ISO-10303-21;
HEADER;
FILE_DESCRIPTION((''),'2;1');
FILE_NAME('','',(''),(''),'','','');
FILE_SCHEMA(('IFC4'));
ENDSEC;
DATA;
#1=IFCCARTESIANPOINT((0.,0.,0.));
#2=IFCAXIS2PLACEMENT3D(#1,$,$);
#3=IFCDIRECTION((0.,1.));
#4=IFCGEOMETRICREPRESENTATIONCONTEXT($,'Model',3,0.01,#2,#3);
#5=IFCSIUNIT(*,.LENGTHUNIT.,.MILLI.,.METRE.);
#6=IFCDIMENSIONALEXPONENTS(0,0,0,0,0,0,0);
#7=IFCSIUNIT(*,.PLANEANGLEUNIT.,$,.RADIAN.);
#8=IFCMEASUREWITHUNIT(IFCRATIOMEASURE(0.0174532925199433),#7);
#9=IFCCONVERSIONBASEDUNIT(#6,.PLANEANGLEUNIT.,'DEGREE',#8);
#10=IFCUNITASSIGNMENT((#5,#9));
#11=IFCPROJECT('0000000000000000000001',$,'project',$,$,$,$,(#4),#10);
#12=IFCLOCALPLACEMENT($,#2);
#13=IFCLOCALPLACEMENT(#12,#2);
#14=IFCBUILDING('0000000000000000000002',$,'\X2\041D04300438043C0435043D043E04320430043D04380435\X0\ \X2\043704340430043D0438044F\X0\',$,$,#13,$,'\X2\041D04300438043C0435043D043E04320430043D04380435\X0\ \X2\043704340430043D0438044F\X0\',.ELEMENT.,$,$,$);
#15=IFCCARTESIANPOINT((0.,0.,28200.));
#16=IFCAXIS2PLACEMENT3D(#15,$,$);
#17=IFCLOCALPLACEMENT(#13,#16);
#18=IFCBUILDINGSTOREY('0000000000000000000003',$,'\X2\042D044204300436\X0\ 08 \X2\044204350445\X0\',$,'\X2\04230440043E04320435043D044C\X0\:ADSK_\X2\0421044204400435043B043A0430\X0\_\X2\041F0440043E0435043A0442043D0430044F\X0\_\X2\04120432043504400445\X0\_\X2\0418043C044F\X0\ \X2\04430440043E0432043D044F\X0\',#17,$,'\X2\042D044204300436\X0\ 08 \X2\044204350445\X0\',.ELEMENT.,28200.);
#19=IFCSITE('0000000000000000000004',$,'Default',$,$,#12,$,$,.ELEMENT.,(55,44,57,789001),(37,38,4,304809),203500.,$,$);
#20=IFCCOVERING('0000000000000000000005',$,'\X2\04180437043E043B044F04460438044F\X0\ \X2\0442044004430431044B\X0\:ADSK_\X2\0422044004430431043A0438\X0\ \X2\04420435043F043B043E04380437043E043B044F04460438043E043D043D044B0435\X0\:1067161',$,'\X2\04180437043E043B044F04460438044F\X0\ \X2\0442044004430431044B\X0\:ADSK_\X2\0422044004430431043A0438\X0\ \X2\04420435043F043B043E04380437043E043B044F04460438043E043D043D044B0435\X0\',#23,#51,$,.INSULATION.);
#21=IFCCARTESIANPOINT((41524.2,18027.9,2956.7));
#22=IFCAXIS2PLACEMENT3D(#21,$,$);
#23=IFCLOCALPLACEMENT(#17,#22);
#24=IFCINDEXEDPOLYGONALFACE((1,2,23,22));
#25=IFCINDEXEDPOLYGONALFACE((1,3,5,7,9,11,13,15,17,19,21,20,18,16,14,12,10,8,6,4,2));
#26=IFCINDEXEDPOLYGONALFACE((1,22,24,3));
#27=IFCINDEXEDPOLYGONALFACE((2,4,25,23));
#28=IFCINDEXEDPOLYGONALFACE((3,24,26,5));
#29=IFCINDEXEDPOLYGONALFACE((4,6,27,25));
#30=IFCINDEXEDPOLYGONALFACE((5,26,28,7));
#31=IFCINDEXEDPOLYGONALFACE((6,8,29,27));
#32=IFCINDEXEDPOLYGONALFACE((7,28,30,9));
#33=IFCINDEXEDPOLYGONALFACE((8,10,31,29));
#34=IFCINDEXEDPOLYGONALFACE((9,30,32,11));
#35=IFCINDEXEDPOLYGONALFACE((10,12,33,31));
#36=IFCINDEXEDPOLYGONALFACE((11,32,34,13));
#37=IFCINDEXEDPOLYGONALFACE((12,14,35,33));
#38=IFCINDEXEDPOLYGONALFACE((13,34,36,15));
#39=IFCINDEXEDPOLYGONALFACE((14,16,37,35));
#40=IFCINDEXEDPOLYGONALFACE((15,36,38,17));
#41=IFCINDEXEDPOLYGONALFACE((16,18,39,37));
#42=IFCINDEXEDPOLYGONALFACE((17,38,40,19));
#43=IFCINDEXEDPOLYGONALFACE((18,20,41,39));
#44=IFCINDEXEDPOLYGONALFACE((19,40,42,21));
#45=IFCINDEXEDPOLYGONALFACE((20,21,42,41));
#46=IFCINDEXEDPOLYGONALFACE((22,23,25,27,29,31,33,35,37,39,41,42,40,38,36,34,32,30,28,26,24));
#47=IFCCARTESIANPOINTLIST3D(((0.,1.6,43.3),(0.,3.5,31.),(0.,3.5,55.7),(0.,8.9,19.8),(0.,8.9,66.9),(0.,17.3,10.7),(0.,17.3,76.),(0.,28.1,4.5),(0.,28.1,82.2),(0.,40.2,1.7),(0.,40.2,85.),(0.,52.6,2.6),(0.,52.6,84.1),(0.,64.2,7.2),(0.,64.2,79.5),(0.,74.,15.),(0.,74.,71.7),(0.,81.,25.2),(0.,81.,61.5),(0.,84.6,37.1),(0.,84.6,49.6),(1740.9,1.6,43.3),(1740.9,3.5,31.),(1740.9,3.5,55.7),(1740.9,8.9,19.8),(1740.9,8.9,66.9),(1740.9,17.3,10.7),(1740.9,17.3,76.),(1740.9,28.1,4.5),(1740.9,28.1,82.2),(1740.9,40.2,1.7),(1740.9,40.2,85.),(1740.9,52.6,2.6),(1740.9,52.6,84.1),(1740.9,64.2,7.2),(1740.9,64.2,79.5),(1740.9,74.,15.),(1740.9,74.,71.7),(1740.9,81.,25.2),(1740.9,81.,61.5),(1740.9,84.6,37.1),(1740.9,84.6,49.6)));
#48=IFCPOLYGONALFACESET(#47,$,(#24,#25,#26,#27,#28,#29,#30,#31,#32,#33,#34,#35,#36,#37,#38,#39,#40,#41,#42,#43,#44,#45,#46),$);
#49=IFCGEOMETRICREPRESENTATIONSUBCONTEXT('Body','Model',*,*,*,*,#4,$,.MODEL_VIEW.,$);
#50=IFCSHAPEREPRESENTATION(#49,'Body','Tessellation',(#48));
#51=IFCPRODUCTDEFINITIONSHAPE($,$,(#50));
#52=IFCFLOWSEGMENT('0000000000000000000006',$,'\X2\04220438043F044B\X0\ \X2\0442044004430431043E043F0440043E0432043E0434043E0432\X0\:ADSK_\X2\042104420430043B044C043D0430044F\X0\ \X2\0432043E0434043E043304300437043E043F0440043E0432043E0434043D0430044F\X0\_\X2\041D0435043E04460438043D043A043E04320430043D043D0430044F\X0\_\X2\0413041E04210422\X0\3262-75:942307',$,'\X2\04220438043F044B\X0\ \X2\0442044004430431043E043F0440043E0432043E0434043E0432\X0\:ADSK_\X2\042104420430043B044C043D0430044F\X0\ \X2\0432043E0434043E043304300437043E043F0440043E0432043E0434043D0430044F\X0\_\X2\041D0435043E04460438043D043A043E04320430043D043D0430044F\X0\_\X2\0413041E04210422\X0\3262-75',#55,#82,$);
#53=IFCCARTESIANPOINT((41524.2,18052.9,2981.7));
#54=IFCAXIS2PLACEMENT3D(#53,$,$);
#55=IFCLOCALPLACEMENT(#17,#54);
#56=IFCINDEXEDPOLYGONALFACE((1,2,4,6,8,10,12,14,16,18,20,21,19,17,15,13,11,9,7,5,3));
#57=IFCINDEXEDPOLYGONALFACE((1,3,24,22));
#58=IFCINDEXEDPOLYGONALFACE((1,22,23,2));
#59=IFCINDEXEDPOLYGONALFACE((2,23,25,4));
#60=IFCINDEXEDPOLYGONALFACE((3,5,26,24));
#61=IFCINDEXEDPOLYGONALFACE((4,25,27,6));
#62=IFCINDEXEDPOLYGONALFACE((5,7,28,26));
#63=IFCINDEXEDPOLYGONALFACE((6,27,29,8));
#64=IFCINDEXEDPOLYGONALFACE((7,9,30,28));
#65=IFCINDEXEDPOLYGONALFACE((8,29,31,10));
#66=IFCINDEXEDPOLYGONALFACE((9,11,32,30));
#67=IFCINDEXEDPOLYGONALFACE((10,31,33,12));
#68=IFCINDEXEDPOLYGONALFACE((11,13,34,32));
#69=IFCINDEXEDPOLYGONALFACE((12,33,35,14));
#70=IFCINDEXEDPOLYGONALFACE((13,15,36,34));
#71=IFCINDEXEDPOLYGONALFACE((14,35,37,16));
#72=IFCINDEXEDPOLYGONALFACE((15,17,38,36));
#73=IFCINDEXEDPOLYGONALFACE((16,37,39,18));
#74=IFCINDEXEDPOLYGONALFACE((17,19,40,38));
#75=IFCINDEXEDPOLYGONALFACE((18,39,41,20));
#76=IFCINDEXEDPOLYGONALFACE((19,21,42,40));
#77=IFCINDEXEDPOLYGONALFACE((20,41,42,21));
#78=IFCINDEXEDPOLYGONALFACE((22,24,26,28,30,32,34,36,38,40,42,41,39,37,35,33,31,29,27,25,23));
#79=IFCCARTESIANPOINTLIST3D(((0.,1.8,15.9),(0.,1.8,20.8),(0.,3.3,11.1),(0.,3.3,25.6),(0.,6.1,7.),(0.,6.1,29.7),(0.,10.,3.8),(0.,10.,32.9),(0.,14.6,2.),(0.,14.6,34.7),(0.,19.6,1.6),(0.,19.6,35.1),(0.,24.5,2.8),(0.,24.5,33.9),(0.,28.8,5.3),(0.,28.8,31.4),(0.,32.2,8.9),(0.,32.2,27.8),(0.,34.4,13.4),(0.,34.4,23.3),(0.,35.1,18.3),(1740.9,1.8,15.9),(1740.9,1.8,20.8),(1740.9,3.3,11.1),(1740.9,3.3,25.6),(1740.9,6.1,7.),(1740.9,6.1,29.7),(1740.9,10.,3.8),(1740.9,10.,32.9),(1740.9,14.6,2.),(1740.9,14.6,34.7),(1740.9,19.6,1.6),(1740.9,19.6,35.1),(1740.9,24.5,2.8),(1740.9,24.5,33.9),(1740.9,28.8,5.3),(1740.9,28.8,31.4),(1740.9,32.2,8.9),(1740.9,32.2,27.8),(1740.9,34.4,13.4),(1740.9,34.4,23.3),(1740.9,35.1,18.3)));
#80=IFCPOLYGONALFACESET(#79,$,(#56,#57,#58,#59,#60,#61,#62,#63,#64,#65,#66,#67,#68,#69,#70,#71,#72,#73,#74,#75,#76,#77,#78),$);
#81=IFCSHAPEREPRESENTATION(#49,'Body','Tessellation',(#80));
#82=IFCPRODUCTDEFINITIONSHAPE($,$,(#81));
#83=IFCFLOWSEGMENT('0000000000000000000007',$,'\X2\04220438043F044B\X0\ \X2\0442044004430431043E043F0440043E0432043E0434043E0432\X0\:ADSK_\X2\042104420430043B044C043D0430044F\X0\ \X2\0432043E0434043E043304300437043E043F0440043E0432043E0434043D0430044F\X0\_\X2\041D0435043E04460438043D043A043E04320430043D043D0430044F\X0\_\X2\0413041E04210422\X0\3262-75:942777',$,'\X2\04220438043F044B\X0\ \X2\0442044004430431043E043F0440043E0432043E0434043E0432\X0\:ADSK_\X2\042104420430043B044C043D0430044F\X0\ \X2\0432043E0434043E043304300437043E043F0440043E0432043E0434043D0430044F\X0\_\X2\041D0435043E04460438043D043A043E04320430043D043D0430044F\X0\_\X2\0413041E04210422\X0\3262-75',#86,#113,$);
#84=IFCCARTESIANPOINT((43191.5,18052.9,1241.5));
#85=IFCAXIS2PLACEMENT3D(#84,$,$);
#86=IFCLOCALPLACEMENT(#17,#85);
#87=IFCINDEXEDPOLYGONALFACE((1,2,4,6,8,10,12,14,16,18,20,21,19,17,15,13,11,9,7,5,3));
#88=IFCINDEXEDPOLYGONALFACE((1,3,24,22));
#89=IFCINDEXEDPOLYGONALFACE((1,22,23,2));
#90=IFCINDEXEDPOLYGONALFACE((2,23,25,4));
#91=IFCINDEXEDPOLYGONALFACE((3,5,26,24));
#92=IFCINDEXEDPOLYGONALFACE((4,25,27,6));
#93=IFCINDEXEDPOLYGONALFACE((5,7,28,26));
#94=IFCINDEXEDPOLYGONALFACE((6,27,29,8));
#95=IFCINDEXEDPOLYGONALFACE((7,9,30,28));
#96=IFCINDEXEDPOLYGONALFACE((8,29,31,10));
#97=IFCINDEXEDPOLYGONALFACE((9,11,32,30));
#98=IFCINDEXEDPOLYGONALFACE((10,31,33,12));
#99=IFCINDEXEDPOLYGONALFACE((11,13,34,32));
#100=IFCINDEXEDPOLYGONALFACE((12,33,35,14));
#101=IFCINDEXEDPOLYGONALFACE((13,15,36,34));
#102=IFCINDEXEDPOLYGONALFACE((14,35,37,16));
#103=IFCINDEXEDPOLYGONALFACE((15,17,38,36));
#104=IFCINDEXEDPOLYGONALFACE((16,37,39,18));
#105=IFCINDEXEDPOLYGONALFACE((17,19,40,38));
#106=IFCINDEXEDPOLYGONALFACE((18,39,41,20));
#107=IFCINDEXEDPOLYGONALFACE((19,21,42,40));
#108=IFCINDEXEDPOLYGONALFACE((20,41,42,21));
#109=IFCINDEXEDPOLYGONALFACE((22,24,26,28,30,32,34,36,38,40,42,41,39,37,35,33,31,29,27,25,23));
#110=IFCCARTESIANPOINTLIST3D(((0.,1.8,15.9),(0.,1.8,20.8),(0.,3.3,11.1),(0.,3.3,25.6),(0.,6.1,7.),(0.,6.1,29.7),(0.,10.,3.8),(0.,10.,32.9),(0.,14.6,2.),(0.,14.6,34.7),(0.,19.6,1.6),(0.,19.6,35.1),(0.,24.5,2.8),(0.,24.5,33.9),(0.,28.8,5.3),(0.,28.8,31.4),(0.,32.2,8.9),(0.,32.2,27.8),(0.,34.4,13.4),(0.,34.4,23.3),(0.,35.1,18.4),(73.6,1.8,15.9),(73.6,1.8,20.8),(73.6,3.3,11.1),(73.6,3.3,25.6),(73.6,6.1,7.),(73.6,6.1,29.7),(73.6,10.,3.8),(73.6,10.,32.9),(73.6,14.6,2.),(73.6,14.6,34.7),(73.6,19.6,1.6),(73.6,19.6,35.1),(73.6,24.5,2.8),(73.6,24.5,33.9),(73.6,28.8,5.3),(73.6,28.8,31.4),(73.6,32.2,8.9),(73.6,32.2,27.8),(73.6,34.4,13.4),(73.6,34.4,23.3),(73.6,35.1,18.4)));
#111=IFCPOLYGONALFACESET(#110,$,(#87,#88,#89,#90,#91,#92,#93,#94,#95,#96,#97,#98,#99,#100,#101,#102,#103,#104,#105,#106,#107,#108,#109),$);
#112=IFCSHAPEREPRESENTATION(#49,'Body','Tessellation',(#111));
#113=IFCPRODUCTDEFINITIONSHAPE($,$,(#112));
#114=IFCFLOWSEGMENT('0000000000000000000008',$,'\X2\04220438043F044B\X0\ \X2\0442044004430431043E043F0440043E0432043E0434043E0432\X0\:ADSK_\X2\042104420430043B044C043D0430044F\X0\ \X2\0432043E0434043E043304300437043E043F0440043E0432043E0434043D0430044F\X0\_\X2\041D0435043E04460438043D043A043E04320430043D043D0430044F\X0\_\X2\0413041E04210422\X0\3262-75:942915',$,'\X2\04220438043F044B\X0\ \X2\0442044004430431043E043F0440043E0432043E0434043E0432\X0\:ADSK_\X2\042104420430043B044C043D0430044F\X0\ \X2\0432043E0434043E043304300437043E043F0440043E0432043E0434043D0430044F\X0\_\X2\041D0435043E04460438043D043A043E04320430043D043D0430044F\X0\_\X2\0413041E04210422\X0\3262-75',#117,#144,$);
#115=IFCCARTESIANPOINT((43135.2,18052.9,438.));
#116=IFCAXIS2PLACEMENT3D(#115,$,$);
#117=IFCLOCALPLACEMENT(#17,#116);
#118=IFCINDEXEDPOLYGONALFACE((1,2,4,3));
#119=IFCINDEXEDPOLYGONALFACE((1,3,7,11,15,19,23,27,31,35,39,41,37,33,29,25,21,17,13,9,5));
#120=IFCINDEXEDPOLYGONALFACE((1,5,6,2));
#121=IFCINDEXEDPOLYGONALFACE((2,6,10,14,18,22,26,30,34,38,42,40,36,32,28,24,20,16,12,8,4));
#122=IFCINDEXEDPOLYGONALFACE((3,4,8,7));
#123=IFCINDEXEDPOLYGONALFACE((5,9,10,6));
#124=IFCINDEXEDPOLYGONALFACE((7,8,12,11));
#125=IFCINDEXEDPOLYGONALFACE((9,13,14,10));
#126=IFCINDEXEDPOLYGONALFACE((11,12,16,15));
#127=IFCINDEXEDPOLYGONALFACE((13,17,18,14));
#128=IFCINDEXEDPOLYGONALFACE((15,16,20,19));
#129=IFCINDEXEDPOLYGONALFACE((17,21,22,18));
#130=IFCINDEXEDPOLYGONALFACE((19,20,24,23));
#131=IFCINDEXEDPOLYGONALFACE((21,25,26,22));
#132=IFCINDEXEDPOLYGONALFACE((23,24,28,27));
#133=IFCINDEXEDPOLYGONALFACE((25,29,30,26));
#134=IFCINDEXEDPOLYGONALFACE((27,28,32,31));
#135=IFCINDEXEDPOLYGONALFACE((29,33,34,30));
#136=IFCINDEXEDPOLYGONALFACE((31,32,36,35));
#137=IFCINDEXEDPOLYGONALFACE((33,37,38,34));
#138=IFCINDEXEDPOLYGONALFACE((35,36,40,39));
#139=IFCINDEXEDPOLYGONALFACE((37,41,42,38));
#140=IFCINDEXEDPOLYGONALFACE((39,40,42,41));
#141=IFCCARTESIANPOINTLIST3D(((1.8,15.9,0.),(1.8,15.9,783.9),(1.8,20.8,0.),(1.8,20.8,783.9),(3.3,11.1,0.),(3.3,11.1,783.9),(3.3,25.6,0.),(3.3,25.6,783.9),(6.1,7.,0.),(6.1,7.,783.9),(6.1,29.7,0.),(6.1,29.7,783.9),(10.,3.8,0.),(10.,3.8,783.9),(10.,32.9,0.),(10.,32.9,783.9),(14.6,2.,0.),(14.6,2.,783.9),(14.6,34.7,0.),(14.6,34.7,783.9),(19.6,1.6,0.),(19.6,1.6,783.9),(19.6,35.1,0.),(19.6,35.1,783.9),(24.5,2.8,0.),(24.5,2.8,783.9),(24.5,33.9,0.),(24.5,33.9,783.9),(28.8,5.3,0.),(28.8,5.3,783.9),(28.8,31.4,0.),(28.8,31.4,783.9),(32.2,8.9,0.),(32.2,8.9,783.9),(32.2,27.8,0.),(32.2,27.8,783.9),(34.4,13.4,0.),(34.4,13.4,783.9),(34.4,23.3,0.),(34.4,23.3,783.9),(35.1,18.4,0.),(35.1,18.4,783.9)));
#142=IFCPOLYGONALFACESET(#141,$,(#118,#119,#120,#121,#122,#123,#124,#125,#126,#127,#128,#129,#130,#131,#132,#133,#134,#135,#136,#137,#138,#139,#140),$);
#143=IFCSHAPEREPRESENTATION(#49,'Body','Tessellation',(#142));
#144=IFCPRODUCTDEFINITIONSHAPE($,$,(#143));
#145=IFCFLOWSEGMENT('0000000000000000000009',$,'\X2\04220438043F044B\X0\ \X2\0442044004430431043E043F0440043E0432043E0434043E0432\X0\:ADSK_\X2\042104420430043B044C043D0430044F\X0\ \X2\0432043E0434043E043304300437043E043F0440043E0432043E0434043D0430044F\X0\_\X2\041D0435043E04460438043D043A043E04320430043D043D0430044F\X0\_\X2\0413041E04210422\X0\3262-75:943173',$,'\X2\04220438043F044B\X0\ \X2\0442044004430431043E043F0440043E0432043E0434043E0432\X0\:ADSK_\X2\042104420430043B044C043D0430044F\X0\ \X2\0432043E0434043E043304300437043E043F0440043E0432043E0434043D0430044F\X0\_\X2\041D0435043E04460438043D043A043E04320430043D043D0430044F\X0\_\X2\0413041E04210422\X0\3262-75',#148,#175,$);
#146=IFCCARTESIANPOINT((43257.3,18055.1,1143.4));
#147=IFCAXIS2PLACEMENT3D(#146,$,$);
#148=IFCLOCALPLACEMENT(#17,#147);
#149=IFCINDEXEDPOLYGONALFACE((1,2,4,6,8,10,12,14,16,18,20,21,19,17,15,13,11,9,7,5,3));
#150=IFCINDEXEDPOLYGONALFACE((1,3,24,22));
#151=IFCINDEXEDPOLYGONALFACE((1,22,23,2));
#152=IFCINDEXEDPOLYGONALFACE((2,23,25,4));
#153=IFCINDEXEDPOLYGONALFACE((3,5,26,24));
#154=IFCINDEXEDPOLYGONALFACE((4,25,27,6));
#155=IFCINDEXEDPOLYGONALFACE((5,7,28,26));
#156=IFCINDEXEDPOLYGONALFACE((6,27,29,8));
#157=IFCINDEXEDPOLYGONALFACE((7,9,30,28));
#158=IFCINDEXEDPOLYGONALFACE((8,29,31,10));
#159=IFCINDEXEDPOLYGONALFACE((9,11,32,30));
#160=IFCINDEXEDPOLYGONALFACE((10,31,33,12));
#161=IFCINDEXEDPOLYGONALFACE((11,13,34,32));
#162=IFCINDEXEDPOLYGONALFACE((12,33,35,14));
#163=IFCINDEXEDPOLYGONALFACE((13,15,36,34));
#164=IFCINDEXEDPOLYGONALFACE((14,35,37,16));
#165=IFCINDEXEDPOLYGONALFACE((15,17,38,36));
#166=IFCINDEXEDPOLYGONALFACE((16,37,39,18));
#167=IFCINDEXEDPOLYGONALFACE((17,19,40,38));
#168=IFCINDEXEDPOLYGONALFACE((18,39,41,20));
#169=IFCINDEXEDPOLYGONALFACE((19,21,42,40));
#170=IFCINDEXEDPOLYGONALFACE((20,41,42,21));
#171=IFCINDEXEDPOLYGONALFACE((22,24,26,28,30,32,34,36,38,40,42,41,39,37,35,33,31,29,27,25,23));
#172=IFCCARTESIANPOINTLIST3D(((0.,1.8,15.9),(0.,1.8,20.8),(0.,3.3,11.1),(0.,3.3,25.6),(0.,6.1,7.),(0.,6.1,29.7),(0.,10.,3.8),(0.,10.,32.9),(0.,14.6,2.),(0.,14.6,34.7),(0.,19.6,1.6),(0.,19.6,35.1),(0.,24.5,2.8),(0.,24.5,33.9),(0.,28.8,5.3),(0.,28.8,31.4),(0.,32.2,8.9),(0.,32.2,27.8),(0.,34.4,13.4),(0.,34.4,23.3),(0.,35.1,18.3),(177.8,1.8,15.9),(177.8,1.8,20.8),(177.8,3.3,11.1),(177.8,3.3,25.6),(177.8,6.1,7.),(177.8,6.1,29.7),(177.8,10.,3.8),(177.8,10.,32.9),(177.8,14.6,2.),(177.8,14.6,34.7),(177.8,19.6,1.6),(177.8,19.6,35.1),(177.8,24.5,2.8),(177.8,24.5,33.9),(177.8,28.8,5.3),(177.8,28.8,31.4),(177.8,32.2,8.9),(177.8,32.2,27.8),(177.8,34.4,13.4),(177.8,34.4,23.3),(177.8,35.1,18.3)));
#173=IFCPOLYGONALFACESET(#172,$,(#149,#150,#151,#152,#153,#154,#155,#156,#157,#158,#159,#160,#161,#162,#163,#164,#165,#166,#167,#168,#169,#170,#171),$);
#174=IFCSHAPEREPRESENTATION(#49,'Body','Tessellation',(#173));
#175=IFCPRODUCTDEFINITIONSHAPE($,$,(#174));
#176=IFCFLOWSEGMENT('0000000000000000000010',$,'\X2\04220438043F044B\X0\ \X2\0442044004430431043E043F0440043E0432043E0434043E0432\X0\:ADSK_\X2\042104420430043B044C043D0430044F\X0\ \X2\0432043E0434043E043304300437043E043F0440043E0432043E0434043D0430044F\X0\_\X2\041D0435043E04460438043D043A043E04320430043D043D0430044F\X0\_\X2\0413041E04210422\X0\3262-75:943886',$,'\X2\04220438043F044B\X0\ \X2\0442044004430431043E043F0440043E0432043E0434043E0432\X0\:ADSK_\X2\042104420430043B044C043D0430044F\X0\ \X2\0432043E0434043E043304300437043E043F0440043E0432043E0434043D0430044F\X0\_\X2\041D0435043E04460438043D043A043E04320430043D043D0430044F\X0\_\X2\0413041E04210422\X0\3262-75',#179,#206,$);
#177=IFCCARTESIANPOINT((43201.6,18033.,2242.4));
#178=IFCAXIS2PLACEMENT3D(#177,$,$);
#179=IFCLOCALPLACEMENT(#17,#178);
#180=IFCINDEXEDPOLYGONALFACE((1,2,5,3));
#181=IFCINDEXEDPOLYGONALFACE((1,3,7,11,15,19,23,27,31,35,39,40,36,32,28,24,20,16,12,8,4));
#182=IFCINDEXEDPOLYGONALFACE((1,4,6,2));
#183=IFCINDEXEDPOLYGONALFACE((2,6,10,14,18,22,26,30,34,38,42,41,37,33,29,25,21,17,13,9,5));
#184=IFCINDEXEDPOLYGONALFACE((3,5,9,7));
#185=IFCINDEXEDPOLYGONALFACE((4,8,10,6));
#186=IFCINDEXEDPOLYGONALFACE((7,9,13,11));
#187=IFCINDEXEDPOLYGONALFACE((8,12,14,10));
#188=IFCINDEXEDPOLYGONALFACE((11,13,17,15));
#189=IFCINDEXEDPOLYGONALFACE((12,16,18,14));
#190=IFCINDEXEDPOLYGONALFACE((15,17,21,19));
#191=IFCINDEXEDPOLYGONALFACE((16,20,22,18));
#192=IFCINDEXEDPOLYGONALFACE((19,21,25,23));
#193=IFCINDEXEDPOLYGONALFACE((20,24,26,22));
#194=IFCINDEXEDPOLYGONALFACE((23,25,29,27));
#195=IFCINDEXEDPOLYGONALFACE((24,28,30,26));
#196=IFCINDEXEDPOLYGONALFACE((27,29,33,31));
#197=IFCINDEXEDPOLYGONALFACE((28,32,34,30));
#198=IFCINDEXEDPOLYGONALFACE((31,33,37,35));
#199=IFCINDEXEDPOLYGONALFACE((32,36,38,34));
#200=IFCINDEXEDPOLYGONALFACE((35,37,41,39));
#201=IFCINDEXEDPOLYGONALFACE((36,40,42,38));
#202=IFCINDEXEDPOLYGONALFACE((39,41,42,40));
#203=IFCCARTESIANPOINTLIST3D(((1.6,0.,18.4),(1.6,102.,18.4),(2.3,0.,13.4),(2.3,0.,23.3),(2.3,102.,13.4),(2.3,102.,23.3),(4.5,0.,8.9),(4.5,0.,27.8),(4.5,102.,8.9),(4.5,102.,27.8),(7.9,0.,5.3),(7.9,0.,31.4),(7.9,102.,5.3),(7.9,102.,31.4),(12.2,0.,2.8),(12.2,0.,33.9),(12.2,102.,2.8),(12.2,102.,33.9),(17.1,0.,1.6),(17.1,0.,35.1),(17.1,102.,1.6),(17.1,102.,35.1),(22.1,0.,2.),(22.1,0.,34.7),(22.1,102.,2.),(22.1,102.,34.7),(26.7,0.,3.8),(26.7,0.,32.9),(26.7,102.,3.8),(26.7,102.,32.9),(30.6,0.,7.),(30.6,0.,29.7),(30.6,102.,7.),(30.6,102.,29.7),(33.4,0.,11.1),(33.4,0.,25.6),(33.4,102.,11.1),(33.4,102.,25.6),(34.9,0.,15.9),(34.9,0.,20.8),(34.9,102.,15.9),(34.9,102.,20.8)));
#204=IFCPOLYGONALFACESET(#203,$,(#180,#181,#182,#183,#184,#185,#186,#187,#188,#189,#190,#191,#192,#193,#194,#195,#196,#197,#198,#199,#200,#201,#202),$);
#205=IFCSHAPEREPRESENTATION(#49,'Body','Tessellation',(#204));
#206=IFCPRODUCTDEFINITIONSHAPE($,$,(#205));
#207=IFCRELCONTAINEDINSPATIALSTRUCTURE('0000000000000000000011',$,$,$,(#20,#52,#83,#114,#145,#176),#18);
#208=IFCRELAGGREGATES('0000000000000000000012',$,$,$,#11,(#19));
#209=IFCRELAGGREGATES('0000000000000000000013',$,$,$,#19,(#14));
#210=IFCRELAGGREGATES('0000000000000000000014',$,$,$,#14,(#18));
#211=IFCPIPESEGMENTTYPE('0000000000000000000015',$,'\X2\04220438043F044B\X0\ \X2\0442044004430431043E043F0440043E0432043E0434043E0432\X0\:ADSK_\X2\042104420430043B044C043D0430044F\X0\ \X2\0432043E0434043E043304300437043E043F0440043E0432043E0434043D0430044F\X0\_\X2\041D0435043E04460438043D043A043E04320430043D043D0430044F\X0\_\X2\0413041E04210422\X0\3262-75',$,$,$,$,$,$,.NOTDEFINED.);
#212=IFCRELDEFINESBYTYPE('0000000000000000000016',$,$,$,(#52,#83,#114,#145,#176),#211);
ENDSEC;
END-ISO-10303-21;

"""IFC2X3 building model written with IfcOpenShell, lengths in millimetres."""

from ifc_helpers import new_model, entity, si_unit, converted_unit, direction, frame, origin, origin_2d_with_axis, place, context, subcontext, project, spatial, circle, extrude, type_object, element, save


model = new_model("IFC2X3")

# Units and contexts
model_context = context("Model", 3, precision=0.01, world=origin(), true_north=direction((0.0, 1.0)))
body_context = subcontext(model_context, "Body", "Model", "MODEL_VIEW")
ifc_project = project(units=[si_unit("LENGTHUNIT", "METRE", prefix="MILLI"), converted_unit("PLANEANGLEUNIT", "DEGREE", entity("IfcRatioMeasure", 0.0174532925199433), si_unit("PLANEANGLEUNIT", "RADIAN"), dimensions=[0, 0, 0, 0, 0, 0, 0])], contexts=[model_context])

# Site, building, storey
site_placement = place(None, origin())
site = spatial("IfcSite", under=ifc_project, at=site_placement, Name="Default", CompositionType="ELEMENT", RefLatitude=(55, 44, 57, 789001), RefLongitude=(37, 38, 4, 304809), RefElevation=203500.0)
building_placement = place(site_placement, origin())
building = spatial("IfcBuilding", under=site, at=building_placement, Name="Наименование здания", LongName="Наименование здания", CompositionType="ELEMENT")
storey_placement = place(building_placement, frame((0.0, 0.0, 28200.0)))
storey = spatial("IfcBuildingStorey", under=building, at=storey_placement, Name="Этаж 08 тех", ObjectType="Уровень:ADSK_Стрелка_Проектная_Вверх_Имя уровня", LongName="Этаж 08 тех", CompositionType="ELEMENT", Elevation=28200.0)

# Covering
covering_1_placement = place(storey_placement, frame((41524.2, 18027.9, 2956.7)))
element("IfcCovering", 1, at=covering_1_placement, inside=storey, Name="Изоляция трубы:ADSK_Трубки теплоизоляционные:1067161", ObjectType="Изоляция трубы:ADSK_Трубки теплоизоляционные", PredefinedType="INSULATION", context=body_context, shape_type="SweptSolid", body=[
    extrude(circle(Radius=41.8, at=origin_2d_with_axis()), frame((0.0, 43.4, 43.4), z_axis=(1.0, 0.0, 0.0), x_axis=(0.0, -1.0, 0.0)), (0.0, 0.0, 1.0), 1740.9),
])

# Flow segments
pipe_segment_type = type_object("IfcPipeSegmentType", Name="Типы трубопроводов:ADSK_Стальная водогазопроводная_Неоцинкованная_ГОСТ3262-75", PredefinedType="NOTDEFINED")
flow_segment_1_placement = place(storey_placement, frame((41524.2, 18052.9, 2981.7)))
element("IfcFlowSegment", 2, at=flow_segment_1_placement, inside=storey, type_object=pipe_segment_type, Name="Типы трубопроводов:ADSK_Стальная водогазопроводная_Неоцинкованная_ГОСТ3262-75:942307", ObjectType="Типы трубопроводов:ADSK_Стальная водогазопроводная_Неоцинкованная_ГОСТ3262-75", context=body_context, shape_type="SweptSolid", body=[
    extrude(circle(Radius=16.8, at=origin_2d_with_axis()), frame((0.0, 18.4, 18.4), z_axis=(1.0, 0.0, 0.0), x_axis=(0.0, 1.0, 0.0)), (0.0, 0.0, 1.0), 1740.9),
])
flow_segment_2_placement = place(storey_placement, frame((43191.5, 18052.9, 1241.5)))
element("IfcFlowSegment", 3, at=flow_segment_2_placement, inside=storey, type_object=pipe_segment_type, Name="Типы трубопроводов:ADSK_Стальная водогазопроводная_Неоцинкованная_ГОСТ3262-75:942777", ObjectType="Типы трубопроводов:ADSK_Стальная водогазопроводная_Неоцинкованная_ГОСТ3262-75", context=body_context, shape_type="SweptSolid", body=[
    extrude(circle(Radius=16.8, at=origin_2d_with_axis()), frame((0.0, 18.4, 18.4), z_axis=(1.0, 0.0, 0.0), x_axis=(0.0, 1.0, 0.0)), (0.0, 0.0, 1.0), 73.6),
])
flow_segment_3_placement = place(storey_placement, frame((43135.2, 18052.9, 438.0)))
element("IfcFlowSegment", 4, at=flow_segment_3_placement, inside=storey, type_object=pipe_segment_type, Name="Типы трубопроводов:ADSK_Стальная водогазопроводная_Неоцинкованная_ГОСТ3262-75:942915", ObjectType="Типы трубопроводов:ADSK_Стальная водогазопроводная_Неоцинкованная_ГОСТ3262-75", context=body_context, shape_type="SweptSolid", body=[
    extrude(circle(Radius=16.8, at=origin_2d_with_axis()), frame((18.4, 18.4, 0.0)), (0.0, 0.0, 1.0), 783.9),
])
flow_segment_4_placement = place(storey_placement, frame((43257.3, 18055.1, 1143.4)))
element("IfcFlowSegment", 5, at=flow_segment_4_placement, inside=storey, type_object=pipe_segment_type, Name="Типы трубопроводов:ADSK_Стальная водогазопроводная_Неоцинкованная_ГОСТ3262-75:943173", ObjectType="Типы трубопроводов:ADSK_Стальная водогазопроводная_Неоцинкованная_ГОСТ3262-75", context=body_context, shape_type="SweptSolid", body=[
    extrude(circle(Radius=16.8, at=origin_2d_with_axis()), frame((0.0, 18.4, 18.4), z_axis=(1.0, 0.0, 0.0), x_axis=(0.0, 1.0, 0.0)), (0.0, 0.0, 1.0), 177.8),
])
flow_segment_5_placement = place(storey_placement, frame((43201.6, 18033.0, 2242.4)))
element("IfcFlowSegment", 6, at=flow_segment_5_placement, inside=storey, type_object=pipe_segment_type, Name="Типы трубопроводов:ADSK_Стальная водогазопроводная_Неоцинкованная_ГОСТ3262-75:943886", ObjectType="Типы трубопроводов:ADSK_Стальная водогазопроводная_Неоцинкованная_ГОСТ3262-75", context=body_context, shape_type="SweptSolid", body=[
    extrude(circle(Radius=16.8, at=origin_2d_with_axis()), frame((18.4, 0.0, 18.4), z_axis=(0.0, 1.0, 0.0), x_axis=(-1.0, 0.0, 0.0)), (0.0, 0.0, 1.0), 102.0),
])

save(model, "model.ifc")
